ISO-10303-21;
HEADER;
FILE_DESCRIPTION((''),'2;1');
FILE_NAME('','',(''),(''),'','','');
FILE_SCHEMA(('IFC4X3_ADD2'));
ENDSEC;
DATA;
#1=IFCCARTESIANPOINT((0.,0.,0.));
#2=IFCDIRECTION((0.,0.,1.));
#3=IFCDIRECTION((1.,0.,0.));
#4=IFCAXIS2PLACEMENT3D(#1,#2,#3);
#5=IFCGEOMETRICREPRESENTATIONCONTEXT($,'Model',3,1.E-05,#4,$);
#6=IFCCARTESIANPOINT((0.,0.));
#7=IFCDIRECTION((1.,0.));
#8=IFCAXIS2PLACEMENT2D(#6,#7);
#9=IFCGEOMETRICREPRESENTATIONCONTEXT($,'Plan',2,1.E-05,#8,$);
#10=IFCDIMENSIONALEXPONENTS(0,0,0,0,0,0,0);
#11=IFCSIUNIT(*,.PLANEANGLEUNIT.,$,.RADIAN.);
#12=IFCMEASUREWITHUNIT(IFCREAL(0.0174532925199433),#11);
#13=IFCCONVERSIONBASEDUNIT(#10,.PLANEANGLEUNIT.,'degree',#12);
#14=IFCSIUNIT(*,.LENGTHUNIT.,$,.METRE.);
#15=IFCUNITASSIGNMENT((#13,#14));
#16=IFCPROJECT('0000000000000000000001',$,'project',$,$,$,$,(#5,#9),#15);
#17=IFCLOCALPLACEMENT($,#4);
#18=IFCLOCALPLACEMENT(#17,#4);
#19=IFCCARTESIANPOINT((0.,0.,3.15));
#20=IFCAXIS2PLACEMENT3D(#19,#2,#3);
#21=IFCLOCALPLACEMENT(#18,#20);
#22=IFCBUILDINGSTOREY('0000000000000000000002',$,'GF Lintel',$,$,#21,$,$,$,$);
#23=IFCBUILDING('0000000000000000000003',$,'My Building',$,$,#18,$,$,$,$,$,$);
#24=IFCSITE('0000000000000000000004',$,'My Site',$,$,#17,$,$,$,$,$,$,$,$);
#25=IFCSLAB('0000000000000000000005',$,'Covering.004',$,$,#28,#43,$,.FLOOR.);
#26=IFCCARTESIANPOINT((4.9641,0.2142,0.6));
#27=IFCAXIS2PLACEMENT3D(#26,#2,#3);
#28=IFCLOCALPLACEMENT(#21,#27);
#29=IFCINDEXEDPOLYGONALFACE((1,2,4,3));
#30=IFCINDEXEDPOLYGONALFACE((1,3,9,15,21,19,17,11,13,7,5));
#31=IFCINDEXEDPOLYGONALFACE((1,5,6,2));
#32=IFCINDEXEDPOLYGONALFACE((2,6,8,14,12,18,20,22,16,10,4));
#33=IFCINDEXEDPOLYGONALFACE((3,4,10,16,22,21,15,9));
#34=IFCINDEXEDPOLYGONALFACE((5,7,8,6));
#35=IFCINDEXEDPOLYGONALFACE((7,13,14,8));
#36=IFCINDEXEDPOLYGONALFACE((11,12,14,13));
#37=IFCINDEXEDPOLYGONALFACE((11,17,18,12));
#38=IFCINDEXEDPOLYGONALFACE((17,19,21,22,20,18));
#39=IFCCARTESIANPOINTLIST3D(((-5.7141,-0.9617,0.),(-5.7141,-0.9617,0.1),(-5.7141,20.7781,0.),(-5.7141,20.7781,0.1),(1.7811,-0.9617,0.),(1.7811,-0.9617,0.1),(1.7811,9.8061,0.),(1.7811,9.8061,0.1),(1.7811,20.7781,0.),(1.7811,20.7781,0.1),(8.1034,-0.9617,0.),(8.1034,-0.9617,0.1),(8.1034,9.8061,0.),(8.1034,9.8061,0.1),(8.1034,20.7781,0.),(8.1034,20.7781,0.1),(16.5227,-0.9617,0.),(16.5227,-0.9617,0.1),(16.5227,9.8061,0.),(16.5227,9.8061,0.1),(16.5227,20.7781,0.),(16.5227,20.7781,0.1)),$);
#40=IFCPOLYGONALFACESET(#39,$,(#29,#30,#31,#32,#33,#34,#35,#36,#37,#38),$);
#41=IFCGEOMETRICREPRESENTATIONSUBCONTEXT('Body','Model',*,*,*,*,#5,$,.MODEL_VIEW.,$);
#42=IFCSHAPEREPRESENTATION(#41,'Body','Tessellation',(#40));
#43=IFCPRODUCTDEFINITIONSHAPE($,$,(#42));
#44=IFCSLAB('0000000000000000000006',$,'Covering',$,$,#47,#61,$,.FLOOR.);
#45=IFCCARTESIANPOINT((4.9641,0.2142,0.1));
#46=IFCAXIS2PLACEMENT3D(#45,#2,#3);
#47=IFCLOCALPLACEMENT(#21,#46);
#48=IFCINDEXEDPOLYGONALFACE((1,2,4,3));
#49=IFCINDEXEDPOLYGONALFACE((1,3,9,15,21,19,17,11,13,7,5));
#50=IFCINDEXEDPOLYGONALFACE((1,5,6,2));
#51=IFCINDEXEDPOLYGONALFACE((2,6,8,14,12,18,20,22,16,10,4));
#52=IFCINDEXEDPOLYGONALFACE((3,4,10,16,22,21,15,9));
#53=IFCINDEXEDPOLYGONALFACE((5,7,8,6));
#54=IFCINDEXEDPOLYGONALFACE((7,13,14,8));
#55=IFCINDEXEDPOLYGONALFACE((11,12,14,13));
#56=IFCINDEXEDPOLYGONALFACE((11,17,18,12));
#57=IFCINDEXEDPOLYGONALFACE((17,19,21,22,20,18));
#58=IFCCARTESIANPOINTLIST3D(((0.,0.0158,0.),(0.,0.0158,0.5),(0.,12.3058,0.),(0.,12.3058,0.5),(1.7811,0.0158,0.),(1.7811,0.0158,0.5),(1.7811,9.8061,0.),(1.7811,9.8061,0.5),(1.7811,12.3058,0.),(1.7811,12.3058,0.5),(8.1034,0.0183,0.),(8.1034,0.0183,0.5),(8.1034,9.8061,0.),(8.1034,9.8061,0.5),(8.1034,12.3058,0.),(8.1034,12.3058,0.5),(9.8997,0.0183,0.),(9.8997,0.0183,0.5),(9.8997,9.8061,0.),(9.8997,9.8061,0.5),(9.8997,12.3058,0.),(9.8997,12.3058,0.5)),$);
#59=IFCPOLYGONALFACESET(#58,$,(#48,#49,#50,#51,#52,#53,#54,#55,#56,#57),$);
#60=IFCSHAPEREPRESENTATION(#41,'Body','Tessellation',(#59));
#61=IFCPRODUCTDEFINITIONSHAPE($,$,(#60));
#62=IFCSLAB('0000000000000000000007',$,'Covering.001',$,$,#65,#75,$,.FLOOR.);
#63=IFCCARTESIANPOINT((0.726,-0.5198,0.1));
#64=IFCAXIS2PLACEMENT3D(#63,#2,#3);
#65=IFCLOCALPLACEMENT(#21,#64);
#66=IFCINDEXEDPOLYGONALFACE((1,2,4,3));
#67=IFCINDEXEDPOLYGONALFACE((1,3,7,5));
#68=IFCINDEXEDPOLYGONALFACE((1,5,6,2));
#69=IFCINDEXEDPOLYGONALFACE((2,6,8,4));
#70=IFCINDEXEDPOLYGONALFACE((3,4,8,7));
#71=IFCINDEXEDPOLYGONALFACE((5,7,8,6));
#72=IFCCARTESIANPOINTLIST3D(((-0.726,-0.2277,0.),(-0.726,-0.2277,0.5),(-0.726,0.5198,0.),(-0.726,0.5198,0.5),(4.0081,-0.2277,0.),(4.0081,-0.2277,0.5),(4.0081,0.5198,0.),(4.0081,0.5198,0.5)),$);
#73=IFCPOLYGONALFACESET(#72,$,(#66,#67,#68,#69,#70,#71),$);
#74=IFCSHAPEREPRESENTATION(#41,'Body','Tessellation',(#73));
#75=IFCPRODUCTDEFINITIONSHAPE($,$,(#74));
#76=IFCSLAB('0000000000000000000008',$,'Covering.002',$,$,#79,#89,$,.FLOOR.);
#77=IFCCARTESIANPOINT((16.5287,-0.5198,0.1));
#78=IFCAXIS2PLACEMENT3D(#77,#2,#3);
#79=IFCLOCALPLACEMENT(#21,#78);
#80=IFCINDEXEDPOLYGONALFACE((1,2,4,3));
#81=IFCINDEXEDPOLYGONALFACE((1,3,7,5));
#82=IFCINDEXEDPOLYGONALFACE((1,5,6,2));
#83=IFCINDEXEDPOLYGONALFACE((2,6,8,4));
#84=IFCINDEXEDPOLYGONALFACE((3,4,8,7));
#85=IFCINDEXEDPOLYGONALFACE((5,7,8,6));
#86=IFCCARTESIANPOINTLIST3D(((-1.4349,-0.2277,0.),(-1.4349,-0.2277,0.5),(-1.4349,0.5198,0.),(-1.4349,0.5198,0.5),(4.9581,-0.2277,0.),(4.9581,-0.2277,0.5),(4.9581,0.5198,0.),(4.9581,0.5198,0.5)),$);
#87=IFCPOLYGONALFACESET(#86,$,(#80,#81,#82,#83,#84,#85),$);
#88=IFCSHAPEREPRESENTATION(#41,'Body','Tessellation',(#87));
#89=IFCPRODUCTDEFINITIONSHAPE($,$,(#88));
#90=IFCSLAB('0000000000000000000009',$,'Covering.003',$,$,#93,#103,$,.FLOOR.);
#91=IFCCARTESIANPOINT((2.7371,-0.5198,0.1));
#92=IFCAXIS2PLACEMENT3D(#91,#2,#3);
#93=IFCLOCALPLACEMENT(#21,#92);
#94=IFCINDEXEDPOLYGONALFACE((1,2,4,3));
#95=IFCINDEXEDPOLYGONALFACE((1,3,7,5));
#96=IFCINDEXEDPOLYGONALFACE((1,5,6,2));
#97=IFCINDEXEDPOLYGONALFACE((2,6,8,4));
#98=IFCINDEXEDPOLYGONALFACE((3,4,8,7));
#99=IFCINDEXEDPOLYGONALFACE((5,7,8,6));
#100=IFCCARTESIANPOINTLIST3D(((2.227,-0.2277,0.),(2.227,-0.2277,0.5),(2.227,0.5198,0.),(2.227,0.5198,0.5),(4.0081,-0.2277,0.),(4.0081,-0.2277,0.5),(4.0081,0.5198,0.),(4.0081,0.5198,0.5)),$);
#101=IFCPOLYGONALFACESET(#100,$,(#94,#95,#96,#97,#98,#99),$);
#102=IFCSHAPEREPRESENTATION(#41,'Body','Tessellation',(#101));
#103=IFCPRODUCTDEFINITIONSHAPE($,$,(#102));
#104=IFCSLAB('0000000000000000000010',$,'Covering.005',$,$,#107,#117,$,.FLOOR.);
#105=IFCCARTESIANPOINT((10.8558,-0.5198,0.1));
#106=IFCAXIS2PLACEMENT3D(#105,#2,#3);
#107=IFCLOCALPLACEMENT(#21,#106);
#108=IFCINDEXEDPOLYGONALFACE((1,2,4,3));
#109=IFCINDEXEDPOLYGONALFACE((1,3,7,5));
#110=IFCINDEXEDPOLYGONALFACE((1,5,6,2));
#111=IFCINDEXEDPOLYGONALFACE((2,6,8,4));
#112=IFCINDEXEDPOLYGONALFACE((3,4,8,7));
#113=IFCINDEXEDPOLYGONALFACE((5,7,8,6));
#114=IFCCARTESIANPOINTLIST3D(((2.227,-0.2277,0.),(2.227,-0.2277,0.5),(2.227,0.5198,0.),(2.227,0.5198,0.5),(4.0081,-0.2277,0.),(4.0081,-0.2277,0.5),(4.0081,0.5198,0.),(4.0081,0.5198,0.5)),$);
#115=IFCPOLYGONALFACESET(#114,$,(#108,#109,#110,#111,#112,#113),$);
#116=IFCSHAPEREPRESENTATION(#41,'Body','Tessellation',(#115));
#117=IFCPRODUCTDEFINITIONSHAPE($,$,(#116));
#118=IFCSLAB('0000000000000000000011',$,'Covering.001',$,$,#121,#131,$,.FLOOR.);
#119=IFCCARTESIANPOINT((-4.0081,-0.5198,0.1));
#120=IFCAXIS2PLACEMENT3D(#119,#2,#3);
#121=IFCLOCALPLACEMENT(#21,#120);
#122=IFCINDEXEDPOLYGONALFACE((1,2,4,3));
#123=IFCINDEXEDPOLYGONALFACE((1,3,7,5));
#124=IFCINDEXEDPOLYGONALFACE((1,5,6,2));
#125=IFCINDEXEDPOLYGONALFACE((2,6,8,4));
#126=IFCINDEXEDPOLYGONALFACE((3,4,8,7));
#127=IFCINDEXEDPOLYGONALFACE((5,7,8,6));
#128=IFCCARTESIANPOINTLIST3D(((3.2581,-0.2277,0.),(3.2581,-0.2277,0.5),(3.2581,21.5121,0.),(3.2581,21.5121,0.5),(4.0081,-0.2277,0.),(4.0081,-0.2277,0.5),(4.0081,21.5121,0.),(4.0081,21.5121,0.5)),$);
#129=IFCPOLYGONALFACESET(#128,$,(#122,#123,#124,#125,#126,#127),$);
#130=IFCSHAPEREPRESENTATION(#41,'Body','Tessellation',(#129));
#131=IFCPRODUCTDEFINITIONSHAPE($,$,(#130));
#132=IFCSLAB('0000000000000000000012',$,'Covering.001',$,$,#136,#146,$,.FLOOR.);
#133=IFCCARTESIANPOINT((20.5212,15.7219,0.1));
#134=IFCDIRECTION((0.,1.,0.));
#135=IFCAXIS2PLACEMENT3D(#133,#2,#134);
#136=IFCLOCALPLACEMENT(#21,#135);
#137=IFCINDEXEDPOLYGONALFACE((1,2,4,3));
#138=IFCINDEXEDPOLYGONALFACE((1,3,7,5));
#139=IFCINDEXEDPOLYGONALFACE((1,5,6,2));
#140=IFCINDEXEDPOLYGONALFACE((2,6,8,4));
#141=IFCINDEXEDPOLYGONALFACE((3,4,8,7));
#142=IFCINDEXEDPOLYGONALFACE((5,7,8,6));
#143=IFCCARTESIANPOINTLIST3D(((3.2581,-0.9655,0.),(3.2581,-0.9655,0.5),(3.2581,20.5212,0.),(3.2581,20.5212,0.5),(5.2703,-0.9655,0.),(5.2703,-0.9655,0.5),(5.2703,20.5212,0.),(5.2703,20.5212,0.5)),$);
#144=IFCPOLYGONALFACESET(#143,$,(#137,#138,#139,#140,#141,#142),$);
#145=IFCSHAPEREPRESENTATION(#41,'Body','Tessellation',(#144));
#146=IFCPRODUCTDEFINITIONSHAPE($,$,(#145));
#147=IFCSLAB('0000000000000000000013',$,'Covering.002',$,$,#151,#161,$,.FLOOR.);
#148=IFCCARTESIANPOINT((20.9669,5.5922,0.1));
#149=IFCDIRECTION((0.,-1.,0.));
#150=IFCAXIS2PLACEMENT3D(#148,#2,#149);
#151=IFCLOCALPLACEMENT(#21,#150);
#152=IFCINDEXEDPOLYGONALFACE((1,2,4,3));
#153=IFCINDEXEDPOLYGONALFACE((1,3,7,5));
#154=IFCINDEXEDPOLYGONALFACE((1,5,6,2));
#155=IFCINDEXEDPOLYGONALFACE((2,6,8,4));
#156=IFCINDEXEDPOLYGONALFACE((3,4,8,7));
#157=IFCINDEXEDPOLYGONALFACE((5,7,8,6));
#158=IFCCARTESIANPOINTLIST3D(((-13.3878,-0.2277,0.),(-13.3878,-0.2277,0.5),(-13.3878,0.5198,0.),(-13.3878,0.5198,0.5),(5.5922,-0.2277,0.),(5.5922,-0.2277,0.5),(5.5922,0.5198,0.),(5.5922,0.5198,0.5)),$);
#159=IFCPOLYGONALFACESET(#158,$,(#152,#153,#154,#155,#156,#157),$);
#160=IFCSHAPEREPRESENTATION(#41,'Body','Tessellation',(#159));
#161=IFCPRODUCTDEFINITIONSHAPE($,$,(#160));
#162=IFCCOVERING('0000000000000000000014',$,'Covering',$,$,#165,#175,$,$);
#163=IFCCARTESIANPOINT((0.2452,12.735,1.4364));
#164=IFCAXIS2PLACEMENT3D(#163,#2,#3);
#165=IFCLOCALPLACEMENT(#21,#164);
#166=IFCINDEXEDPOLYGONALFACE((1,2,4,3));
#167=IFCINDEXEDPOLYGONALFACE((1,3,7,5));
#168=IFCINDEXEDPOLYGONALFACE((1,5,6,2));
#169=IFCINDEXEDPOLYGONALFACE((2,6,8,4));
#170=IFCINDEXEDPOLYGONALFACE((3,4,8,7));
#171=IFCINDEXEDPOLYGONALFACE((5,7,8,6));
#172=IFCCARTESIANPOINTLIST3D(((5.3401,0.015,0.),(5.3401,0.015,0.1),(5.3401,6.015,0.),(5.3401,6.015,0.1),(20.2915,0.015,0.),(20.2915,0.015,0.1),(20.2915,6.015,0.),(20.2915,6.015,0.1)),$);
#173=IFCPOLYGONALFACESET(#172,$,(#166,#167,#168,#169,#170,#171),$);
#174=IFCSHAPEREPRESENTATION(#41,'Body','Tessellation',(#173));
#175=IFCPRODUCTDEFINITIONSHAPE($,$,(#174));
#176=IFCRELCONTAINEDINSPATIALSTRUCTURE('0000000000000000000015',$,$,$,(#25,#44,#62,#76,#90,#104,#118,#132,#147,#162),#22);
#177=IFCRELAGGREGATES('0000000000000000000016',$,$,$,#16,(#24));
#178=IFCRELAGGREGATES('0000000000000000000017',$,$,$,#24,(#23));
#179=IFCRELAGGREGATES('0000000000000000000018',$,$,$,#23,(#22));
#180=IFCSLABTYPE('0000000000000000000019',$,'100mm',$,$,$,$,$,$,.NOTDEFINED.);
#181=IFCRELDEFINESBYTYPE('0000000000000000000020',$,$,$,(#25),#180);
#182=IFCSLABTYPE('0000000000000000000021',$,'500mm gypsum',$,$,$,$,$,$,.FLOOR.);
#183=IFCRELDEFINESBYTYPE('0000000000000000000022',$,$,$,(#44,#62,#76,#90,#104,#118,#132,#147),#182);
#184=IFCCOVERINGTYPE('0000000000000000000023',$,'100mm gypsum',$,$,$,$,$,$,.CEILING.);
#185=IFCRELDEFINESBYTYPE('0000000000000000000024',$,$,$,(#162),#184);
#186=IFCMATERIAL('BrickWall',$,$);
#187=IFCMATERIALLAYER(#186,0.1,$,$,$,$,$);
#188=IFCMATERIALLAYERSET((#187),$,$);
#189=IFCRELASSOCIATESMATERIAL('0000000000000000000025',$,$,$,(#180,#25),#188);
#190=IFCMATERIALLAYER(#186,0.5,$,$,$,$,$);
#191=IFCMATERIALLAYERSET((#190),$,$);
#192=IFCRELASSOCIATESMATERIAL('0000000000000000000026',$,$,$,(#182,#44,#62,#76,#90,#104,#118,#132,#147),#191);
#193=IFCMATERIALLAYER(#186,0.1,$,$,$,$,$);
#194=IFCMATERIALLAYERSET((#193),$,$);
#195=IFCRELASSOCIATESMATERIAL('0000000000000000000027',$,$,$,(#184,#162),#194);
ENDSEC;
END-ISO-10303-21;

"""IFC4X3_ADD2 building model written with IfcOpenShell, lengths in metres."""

from ifc_helpers import new_model, entity, si_unit, converted_unit, frame, origin_with_axes, origin_2d_with_axis, place, context, subcontext, project, spatial, line, indexed_curve, outline, extrude, material, layer, layer_set, layer_usage, type_object, element, save


model = new_model("IFC4X3_ADD2")

# Units and contexts
model_context = context("Model", 3, precision=1e-05, world=origin_with_axes())
plan_context = context("Plan", 2, precision=1e-05, world=origin_2d_with_axis())
body_context = subcontext(model_context, "Body", "Model", "MODEL_VIEW")
ifc_project = project(units=[converted_unit("PLANEANGLEUNIT", "degree", entity("IfcReal", 0.0174532925199433), si_unit("PLANEANGLEUNIT", "RADIAN"), dimensions=[0, 0, 0, 0, 0, 0, 0]), si_unit("LENGTHUNIT", "METRE")], contexts=[model_context, plan_context])

# Site, building, storey
site_placement = place(None, origin_with_axes())
site = spatial("IfcSite", under=ifc_project, at=site_placement, Name="My Site")
building_placement = place(site_placement, origin_with_axes())
building = spatial("IfcBuilding", under=site, at=building_placement, Name="My Building")
storey_placement = place(building_placement, frame((0.0, 0.0, 3.15), z_axis=(0.0, 0.0, 1.0), x_axis=(1.0, 0.0, 0.0)))
storey = spatial("IfcBuildingStorey", under=building, at=storey_placement, Name="GF Lintel")

# Slabs
ifc_material = material(Name="BrickWall")
ifc_layer_1 = layer(ifc_material, 0.1)
ifc_layer_set_1 = layer_set([ifc_layer_1])
ifc_layer_usage_1 = layer_usage(ifc_layer_set_1, "AXIS3", "POSITIVE", 0.0)
slab_type_1 = type_object("IfcSlabType", Name="100mm", PredefinedType="NOTDEFINED", material=ifc_layer_set_1)
slab_1_placement = place(storey_placement, frame((4.9641, 0.2142, 0.6), z_axis=(0.0, 0.0, 1.0), x_axis=(1.0, 0.0, 0.0)))
element("IfcSlab", 1, at=slab_1_placement, inside=storey, type_object=slab_type_1, material=ifc_layer_usage_1, Name="Covering.004", PredefinedType="FLOOR", context=body_context, shape_type="SweptSolid", body=[
    extrude(outline(indexed_curve([(8.1034, 9.8061), (1.7811, 9.8061), (1.7811, -0.9617), (-5.7141, -0.9617), (-5.7141, 20.7781), (1.7811, 20.7781), (8.1034, 20.7781), (16.5227, 20.7781), (16.5227, 9.8061), (16.5227, -0.9617), (8.1034, -0.9617)], segments=[line(7, 6), line(6, 5), line(5, 4), line(4, 3), line(3, 2), line(2, 1), line(1, 11), line(11, 10), line(10, 9), line(9, 8), line(8, 7)], self_intersect=False)), None, (0.0, 0.0, 1.0), 0.1),
])
ifc_layer_2 = layer(ifc_material, 0.5)
ifc_layer_set_2 = layer_set([ifc_layer_2])
ifc_layer_usage_2 = layer_usage(ifc_layer_set_2, "AXIS3", "POSITIVE", 0.0)
slab_type_2 = type_object("IfcSlabType", Name="500mm gypsum", PredefinedType="FLOOR", material=ifc_layer_set_2)
slab_2_placement = place(storey_placement, frame((4.9641, 0.2142, 0.1), z_axis=(0.0, 0.0, 1.0), x_axis=(1.0, 0.0, 0.0)))
element("IfcSlab", 2, at=slab_2_placement, inside=storey, type_object=slab_type_2, material=ifc_layer_usage_2, Name="Covering", PredefinedType="FLOOR", context=body_context, shape_type="SweptSolid", body=[
    extrude(outline(indexed_curve([(8.1034, 12.3058), (9.8997, 12.3058), (9.8997, 9.8061), (9.8997, 0.0183), (8.1034, 0.0183), (8.1034, 9.8061), (1.7811, 9.8061), (1.7811, 0.0158), (0.0, 0.0158), (0.0, 12.3058), (1.7811, 12.3058)], segments=[line(5, 4), line(4, 3), line(3, 2), line(2, 1), line(1, 11), line(11, 10), line(10, 9), line(9, 8), line(8, 7), line(7, 6), line(6, 5)], self_intersect=False)), None, (0.0, 0.0, 1.0), 0.5),
])
ifc_layer_usage_3 = layer_usage(ifc_layer_set_2, "AXIS3", "POSITIVE", 0.0)
slab_3_placement = place(storey_placement, frame((0.726, -0.5198, 0.1), z_axis=(0.0, 0.0, 1.0), x_axis=(1.0, 0.0, 0.0)))
element("IfcSlab", 3, at=slab_3_placement, inside=storey, type_object=slab_type_2, material=ifc_layer_usage_3, Name="Covering.001", PredefinedType="FLOOR", context=body_context, shape_type="SweptSolid", body=[
    extrude(outline(indexed_curve([(4.0081, -0.2277), (-0.726, -0.2277), (-0.726, 0.5198), (4.0081, 0.5198)], segments=[line(3, 2), line(2, 1), line(1, 4), line(4, 3)], self_intersect=False)), None, (0.0, 0.0, 1.0), 0.5),
])
ifc_layer_usage_4 = layer_usage(ifc_layer_set_2, "AXIS3", "POSITIVE", 0.0)
slab_4_placement = place(storey_placement, frame((16.5287, -0.5198, 0.1), z_axis=(0.0, 0.0, 1.0), x_axis=(1.0, 0.0, 0.0)))
element("IfcSlab", 4, at=slab_4_placement, inside=storey, type_object=slab_type_2, material=ifc_layer_usage_4, Name="Covering.002", PredefinedType="FLOOR", context=body_context, shape_type="SweptSolid", body=[
    extrude(outline(indexed_curve([(4.9581, 0.5198), (4.9581, -0.2277), (-1.4349, -0.2277), (-1.4349, 0.5198)], segments=[line(3, 2), line(2, 1), line(1, 4), line(4, 3)], self_intersect=False)), None, (0.0, 0.0, 1.0), 0.5),
])
ifc_layer_usage_5 = layer_usage(ifc_layer_set_2, "AXIS3", "POSITIVE", 0.0)
slab_5_placement = place(storey_placement, frame((2.7371, -0.5198, 0.1), z_axis=(0.0, 0.0, 1.0), x_axis=(1.0, 0.0, 0.0)))
element("IfcSlab", 5, at=slab_5_placement, inside=storey, type_object=slab_type_2, material=ifc_layer_usage_5, Name="Covering.003", PredefinedType="FLOOR", context=body_context, shape_type="SweptSolid", body=[
    extrude(outline(indexed_curve([(4.0081, -0.2277), (2.227, -0.2277), (2.227, 0.5198), (4.0081, 0.5198)], segments=[line(4, 1), line(1, 2), line(2, 3), line(3, 4)], self_intersect=False)), None, (0.0, 0.0, 1.0), 0.5),
])
ifc_layer_usage_6 = layer_usage(ifc_layer_set_2, "AXIS3", "POSITIVE", 0.0)
slab_6_placement = place(storey_placement, frame((10.8558, -0.5198, 0.1), z_axis=(0.0, 0.0, 1.0), x_axis=(1.0, 0.0, 0.0)))
element("IfcSlab", 6, at=slab_6_placement, inside=storey, type_object=slab_type_2, material=ifc_layer_usage_6, Name="Covering.005", PredefinedType="FLOOR", context=body_context, shape_type="SweptSolid", body=[
    extrude(outline(indexed_curve([(4.0081, 0.5198), (4.0081, -0.2277), (2.227, -0.2277), (2.227, 0.5198)], segments=[line(3, 2), line(2, 1), line(1, 4), line(4, 3)], self_intersect=False)), None, (0.0, 0.0, 1.0), 0.5),
])
ifc_layer_usage_7 = layer_usage(ifc_layer_set_2, "AXIS3", "POSITIVE", 0.0)
slab_7_placement = place(storey_placement, frame((-4.0081, -0.5198, 0.1), z_axis=(0.0, 0.0, 1.0), x_axis=(1.0, 0.0, 0.0)))
element("IfcSlab", 7, at=slab_7_placement, inside=storey, type_object=slab_type_2, material=ifc_layer_usage_7, Name="Covering.001", PredefinedType="FLOOR", context=body_context, shape_type="SweptSolid", body=[
    extrude(outline(indexed_curve([(3.2581, 21.5121), (3.2581, -0.2277), (4.0081, -0.2277), (4.0081, 21.5121)], segments=[line(3, 2), line(2, 1), line(1, 4), line(4, 3)], self_intersect=False)), None, (0.0, 0.0, 1.0), 0.5),
])
ifc_layer_usage_8 = layer_usage(ifc_layer_set_2, "AXIS3", "POSITIVE", 0.0)
slab_8_placement = place(storey_placement, frame((20.5212, 15.7219, 0.1), z_axis=(0.0, 0.0, 1.0), x_axis=(0.0, 1.0, 0.0)))
element("IfcSlab", 8, at=slab_8_placement, inside=storey, type_object=slab_type_2, material=ifc_layer_usage_8, Name="Covering.001", PredefinedType="FLOOR", context=body_context, shape_type="SweptSolid", body=[
    extrude(outline(indexed_curve([(5.2703, 20.5212), (3.2581, 20.5212), (3.2581, -0.9655), (5.2703, -0.9655)], segments=[line(4, 1), line(1, 2), line(2, 3), line(3, 4)], self_intersect=False)), None, (0.0, 0.0, 1.0), 0.5),
])
ifc_layer_usage_9 = layer_usage(ifc_layer_set_2, "AXIS3", "POSITIVE", 0.0)
slab_9_placement = place(storey_placement, frame((20.9669, 5.5922, 0.1), z_axis=(0.0, 0.0, 1.0), x_axis=(0.0, -1.0, 0.0)))
element("IfcSlab", 9, at=slab_9_placement, inside=storey, type_object=slab_type_2, material=ifc_layer_usage_9, Name="Covering.002", PredefinedType="FLOOR", context=body_context, shape_type="SweptSolid", body=[
    extrude(outline(indexed_curve([(-13.3878, -0.2277), (5.5922, -0.2277), (5.5922, 0.5198), (-13.3878, 0.5198)], segments=[line(3, 2), line(2, 1), line(1, 4), line(4, 3)], self_intersect=False)), None, (0.0, 0.0, 1.0), 0.5),
])

# Covering
ifc_layer_3 = layer(ifc_material, 0.1)
ifc_layer_set_3 = layer_set([ifc_layer_3])
ifc_layer_usage_10 = layer_usage(ifc_layer_set_3, "AXIS3", "POSITIVE", 0.0)
covering_type_1 = type_object("IfcCoveringType", Name="100mm gypsum", PredefinedType="CEILING", material=ifc_layer_set_3)
covering_1_placement = place(storey_placement, frame((0.2452, 12.735, 1.4364), z_axis=(0.0, 0.0, 1.0), x_axis=(1.0, 0.0, 0.0)))
element("IfcCovering", 10, at=covering_1_placement, inside=storey, type_object=covering_type_1, material=ifc_layer_usage_10, Name="Covering", context=body_context, shape_type="SweptSolid", body=[
    extrude(outline(indexed_curve([(5.3401, 0.015), (20.2915, 0.015), (20.2915, 6.015), (5.3401, 6.015)], segments=[line(4, 1), line(1, 2), line(2, 3), line(3, 4)], self_intersect=False)), None, (0.0, 0.0, 1.0), 0.1),
])

save(model, "model.ifc")
